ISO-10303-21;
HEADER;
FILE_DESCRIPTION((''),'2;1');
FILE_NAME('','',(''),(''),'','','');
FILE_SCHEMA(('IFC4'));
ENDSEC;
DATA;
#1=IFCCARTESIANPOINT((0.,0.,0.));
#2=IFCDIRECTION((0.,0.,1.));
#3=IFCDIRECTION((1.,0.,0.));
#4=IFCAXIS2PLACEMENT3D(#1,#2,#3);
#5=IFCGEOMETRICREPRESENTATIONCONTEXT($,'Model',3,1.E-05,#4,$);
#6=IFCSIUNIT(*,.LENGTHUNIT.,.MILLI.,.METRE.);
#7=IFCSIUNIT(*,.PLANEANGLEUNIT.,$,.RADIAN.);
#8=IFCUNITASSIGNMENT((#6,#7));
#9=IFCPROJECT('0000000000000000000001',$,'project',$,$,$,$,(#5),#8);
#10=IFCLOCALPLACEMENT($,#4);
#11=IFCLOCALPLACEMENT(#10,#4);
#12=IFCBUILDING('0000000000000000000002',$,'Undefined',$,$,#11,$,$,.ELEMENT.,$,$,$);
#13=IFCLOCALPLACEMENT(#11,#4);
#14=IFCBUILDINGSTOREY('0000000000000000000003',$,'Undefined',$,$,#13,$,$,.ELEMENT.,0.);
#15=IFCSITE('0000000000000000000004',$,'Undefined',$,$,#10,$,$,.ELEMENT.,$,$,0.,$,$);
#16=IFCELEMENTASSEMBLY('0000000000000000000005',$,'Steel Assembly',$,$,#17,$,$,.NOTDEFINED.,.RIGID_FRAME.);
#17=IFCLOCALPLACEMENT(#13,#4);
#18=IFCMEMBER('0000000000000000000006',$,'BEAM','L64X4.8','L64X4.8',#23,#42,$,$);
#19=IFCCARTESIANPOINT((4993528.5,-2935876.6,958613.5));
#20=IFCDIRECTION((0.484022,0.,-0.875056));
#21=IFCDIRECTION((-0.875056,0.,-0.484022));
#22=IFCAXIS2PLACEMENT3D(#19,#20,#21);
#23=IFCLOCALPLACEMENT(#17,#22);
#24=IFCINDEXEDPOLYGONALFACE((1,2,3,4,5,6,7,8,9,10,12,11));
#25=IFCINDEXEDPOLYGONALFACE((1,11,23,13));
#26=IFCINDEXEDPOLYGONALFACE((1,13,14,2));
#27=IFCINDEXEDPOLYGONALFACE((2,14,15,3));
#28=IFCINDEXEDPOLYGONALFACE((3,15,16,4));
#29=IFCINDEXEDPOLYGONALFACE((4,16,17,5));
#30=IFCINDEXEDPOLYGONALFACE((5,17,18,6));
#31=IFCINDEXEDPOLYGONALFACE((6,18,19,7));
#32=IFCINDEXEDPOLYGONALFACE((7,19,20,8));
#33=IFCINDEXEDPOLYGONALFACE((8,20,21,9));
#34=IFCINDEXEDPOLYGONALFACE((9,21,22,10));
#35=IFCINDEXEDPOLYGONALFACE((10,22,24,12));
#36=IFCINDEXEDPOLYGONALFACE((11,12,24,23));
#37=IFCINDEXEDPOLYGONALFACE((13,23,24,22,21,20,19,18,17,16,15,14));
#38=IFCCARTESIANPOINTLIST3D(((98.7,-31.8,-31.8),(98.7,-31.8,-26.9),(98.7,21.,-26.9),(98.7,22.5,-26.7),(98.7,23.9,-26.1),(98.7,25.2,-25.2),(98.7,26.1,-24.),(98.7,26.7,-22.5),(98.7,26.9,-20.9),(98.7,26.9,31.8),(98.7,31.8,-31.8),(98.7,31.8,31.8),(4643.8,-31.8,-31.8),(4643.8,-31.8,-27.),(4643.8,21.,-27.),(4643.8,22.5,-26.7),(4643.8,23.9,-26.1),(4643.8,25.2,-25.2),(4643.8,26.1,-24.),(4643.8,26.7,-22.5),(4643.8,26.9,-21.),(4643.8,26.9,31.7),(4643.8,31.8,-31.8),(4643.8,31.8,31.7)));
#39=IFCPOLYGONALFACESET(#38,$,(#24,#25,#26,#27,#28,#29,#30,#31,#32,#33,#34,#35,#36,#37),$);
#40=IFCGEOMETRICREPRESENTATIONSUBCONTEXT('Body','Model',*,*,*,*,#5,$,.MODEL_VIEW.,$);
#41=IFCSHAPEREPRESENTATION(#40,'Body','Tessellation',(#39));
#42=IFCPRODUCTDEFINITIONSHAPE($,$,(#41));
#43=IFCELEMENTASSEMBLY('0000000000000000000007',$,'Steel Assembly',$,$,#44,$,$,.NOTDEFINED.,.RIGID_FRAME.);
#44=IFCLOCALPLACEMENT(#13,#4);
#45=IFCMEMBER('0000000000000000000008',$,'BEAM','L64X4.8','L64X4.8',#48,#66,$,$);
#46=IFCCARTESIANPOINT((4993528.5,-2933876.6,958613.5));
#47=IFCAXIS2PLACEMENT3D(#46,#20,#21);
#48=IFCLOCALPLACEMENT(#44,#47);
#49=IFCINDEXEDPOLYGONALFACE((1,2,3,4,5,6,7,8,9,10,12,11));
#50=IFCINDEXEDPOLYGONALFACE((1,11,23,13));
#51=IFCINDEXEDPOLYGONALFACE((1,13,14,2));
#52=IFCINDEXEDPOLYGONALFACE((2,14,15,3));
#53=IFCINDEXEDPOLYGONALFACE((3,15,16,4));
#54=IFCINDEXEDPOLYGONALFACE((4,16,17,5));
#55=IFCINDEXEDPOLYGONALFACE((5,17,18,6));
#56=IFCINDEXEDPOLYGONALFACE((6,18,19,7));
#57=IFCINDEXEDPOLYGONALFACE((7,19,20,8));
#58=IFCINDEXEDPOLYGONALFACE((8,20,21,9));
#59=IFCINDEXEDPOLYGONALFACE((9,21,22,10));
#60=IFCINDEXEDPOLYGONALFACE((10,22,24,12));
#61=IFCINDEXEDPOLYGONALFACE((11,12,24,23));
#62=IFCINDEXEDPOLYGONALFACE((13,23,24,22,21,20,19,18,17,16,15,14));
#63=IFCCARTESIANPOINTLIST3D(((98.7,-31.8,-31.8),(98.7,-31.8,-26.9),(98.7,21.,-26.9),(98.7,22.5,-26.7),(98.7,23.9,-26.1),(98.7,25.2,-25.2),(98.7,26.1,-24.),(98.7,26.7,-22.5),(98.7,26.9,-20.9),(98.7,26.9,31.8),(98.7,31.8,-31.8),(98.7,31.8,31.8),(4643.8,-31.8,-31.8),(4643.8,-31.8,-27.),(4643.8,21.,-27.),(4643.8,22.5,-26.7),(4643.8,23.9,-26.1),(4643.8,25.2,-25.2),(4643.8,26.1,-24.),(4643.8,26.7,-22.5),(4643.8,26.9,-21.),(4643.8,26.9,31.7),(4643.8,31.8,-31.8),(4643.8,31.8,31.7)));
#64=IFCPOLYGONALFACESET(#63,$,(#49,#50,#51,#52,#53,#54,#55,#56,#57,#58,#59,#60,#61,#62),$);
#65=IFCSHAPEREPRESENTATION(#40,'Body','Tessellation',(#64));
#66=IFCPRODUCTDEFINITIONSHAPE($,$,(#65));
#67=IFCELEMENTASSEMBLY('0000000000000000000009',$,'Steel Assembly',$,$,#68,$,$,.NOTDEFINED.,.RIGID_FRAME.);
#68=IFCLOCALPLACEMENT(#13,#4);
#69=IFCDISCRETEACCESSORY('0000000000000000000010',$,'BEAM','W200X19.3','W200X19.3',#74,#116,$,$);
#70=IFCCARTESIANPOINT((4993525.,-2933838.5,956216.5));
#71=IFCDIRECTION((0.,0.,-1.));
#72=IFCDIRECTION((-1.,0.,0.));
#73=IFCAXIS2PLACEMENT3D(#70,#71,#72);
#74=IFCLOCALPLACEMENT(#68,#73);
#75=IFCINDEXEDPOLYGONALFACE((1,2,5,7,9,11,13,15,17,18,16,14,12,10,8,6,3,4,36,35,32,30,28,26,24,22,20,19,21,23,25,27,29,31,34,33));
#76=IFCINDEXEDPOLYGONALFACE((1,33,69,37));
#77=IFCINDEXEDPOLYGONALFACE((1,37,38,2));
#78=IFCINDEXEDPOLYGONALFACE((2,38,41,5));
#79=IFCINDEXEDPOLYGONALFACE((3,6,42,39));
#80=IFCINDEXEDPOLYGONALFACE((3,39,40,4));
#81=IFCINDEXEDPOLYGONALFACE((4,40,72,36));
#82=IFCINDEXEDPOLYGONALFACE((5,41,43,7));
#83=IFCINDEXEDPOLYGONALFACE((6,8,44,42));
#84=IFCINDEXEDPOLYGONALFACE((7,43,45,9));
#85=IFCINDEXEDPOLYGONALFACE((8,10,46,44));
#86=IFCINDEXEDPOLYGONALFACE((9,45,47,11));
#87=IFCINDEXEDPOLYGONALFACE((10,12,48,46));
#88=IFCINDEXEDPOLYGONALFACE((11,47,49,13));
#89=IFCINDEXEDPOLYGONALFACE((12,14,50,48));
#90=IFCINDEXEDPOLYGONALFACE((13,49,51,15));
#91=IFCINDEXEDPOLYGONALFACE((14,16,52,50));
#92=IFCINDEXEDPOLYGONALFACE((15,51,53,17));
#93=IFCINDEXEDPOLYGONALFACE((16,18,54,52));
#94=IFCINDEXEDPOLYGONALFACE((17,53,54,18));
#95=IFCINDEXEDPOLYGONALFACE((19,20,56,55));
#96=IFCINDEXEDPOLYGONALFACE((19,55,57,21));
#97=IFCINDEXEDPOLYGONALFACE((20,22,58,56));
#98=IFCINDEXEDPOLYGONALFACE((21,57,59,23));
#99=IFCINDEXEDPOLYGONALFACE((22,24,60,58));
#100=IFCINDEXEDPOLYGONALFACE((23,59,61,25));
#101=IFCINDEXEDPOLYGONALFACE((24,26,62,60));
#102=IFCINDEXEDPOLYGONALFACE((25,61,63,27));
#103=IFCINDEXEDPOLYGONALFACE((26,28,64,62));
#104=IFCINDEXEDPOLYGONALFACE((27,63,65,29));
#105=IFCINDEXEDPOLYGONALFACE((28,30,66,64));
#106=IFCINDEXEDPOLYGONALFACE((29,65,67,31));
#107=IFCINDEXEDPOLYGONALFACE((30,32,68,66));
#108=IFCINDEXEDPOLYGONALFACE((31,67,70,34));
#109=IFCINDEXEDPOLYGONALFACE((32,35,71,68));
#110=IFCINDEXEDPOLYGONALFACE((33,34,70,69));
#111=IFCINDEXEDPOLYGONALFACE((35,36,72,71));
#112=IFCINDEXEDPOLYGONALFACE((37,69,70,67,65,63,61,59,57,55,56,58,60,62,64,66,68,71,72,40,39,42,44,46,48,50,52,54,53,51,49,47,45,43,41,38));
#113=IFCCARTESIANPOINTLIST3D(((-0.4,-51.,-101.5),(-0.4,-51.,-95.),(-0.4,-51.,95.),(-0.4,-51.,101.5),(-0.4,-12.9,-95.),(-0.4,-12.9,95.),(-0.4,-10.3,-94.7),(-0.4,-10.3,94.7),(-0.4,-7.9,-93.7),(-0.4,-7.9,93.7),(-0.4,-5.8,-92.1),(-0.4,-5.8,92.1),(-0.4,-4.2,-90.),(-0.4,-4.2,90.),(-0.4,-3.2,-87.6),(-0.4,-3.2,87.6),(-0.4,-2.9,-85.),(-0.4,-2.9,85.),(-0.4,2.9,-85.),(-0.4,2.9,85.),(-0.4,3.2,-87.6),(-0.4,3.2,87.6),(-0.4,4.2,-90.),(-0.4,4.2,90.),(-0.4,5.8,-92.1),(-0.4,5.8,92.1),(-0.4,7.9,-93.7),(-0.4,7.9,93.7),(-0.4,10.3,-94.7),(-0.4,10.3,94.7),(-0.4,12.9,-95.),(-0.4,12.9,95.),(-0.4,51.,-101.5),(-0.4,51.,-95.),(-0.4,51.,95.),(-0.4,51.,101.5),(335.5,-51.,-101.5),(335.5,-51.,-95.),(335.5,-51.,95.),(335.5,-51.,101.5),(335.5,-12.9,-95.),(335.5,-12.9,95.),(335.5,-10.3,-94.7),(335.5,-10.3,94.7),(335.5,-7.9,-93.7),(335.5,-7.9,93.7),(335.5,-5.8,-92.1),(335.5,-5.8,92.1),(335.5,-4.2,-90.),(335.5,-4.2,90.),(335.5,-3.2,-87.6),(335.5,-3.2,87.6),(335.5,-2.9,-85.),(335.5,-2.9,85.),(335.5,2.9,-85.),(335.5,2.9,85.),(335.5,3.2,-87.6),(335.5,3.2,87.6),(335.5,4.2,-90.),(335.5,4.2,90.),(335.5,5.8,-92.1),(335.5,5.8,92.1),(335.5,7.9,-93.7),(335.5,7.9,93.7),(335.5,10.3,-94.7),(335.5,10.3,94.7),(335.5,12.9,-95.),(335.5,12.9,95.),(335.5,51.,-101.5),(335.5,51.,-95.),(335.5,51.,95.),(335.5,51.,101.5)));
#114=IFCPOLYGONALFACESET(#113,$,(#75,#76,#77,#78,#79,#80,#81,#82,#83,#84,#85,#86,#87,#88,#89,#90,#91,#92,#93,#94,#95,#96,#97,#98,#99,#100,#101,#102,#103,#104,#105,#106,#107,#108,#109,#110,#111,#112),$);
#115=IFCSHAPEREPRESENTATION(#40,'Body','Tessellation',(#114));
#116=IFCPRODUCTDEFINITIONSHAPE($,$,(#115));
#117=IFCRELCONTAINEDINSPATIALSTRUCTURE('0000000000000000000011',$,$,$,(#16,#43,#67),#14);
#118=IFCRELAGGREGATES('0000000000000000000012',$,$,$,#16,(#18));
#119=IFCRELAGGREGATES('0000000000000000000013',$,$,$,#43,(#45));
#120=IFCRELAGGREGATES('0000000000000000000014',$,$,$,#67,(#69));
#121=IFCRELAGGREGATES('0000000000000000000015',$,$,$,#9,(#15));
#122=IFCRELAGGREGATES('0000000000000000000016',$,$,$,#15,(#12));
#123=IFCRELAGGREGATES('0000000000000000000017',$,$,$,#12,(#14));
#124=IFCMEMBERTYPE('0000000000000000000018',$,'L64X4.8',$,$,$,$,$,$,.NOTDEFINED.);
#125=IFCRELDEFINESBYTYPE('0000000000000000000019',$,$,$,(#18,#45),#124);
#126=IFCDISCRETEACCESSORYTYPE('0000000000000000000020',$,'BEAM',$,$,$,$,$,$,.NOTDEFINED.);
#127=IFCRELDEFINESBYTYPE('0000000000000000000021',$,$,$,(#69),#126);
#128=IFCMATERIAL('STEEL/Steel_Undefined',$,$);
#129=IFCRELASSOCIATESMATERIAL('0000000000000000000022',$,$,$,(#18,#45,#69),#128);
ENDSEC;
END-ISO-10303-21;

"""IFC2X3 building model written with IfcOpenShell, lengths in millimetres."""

from ifc_helpers import new_model, si_unit, frame, origin_with_axes, origin_2d_with_axis, place, context, subcontext, project, spatial, i_section, l_section, extrude, clip, halfspace, material, type_object, element, aggregate, save


model = new_model("IFC2X3")

# Units and contexts
model_context = context("Model", 3, precision=1e-05, world=origin_with_axes())
body_context = subcontext(model_context, "Body", "Model", "MODEL_VIEW")
ifc_project = project(units=[si_unit("LENGTHUNIT", "METRE", prefix="MILLI"), si_unit("PLANEANGLEUNIT", "RADIAN")], contexts=[model_context])

# Site, building, storey
site_placement = place(None, origin_with_axes())
site = spatial("IfcSite", under=ifc_project, at=site_placement, Name="Undefined", CompositionType="ELEMENT", RefElevation=0.0)
building_placement = place(site_placement, origin_with_axes())
building = spatial("IfcBuilding", under=site, at=building_placement, Name="Undefined", CompositionType="ELEMENT")
storey_placement = place(building_placement, origin_with_axes())
storey = spatial("IfcBuildingStorey", under=building, at=storey_placement, Name="Undefined", CompositionType="ELEMENT", Elevation=0.0)

# Element assemblies, members
assembly_1_placement = place(storey_placement, origin_with_axes())
assembly_1 = element("IfcElementAssembly", 1, at=assembly_1_placement, inside=storey, Name="Steel Assembly", AssemblyPlace="NOTDEFINED", PredefinedType="RIGID_FRAME")
ifc_material_1 = material(Name="STEEL/Steel_Undefined")
member_type = type_object("IfcMemberType", Name="L64X4.8", PredefinedType="NOTDEFINED")
member_1_placement = place(assembly_1_placement, frame((4993528.5, -2935876.6, 958613.5), z_axis=(0.484022, 0.0, -0.875056), x_axis=(-0.875056, 0.0, -0.484022)))
member_1 = element("IfcMember", 2, at=member_1_placement, type_object=member_type, material=ifc_material_1, Name="BEAM", Description="L64X4.8", ObjectType="L64X4.8", context=body_context, shape_type="Clipping", body=[
    clip(clip(extrude(l_section(Depth=63.5, Width=63.5, Thickness=4.8, FilletRadius=6.0, at=origin_2d_with_axis()), frame((4698.2, 0.0, 0.0), z_axis=(-1.0, 0.0, 0.0), x_axis=(0.0, -1.0, 0.0)), (0.0, 0.0, 1.0), 4653.8), halfspace(frame((4643.8, 31.8, 0.0), z_axis=(-1.0, 0.0, 0.0), x_axis=(0.0, 0.0, -1.0)), True)), halfspace(frame((98.7, 31.8, 0.0), z_axis=(1.0, 0.0, 0.0), x_axis=(0.0, 0.0, 1.0)), True)),
])
aggregate(assembly_1, [member_1])
assembly_2_placement = place(storey_placement, origin_with_axes())
assembly_2 = element("IfcElementAssembly", 3, at=assembly_2_placement, inside=storey, Name="Steel Assembly", AssemblyPlace="NOTDEFINED", PredefinedType="RIGID_FRAME")
member_2_placement = place(assembly_2_placement, frame((4993528.5, -2933876.6, 958613.5), z_axis=(0.484022, 0.0, -0.875056), x_axis=(-0.875056, 0.0, -0.484022)))
member_2 = element("IfcMember", 4, at=member_2_placement, type_object=member_type, material=ifc_material_1, Name="BEAM", Description="L64X4.8", ObjectType="L64X4.8", context=body_context, shape_type="Clipping", body=[
    clip(clip(extrude(l_section(Depth=63.5, Width=63.5, Thickness=4.8, FilletRadius=6.0, at=origin_2d_with_axis()), frame((4698.2, 0.0, 0.0), z_axis=(-1.0, 0.0, 0.0), x_axis=(0.0, -1.0, 0.0)), (0.0, 0.0, 1.0), 4653.8), halfspace(frame((4643.8, 31.8, 0.0), z_axis=(-1.0, 0.0, 0.0), x_axis=(0.0, 0.0, -1.0)), True)), halfspace(frame((98.7, 31.8, 0.0), z_axis=(1.0, 0.0, 0.0), x_axis=(0.0, 0.0, 1.0)), True)),
])
aggregate(assembly_2, [member_2])

# Element assembly
assembly_3_placement = place(storey_placement, origin_with_axes())
assembly_3 = element("IfcElementAssembly", 5, at=assembly_3_placement, inside=storey, Name="Steel Assembly", AssemblyPlace="NOTDEFINED", PredefinedType="RIGID_FRAME")

# Discrete accessory
discrete_accessory_type_1 = type_object("IfcDiscreteAccessoryType", Name="BEAM")
discrete_accessory_1_placement = place(assembly_3_placement, frame((4993525.0, -2933838.5, 956216.5), z_axis=(0.0, 0.0, -1.0), x_axis=(-1.0, 0.0, 0.0)))
discrete_accessory_1 = element("IfcDiscreteAccessory", 6, at=discrete_accessory_1_placement, type_object=discrete_accessory_type_1, material=ifc_material_1, Name="BEAM", Description="W200X19.3", ObjectType="W200X19.3", context=body_context, shape_type="Clipping", body=[
    clip(clip(extrude(i_section(OverallWidth=102.0, OverallDepth=203.0, WebThickness=5.8, FlangeThickness=6.5, FilletRadius=10.0, at=origin_2d_with_axis()), frame((335.5, 0.0, 0.0), z_axis=(-1.0, 0.0, 0.0), x_axis=(0.0, -1.0, 0.0)), (0.0, 0.0, 1.0), 335.9), halfspace(frame((335.5, 0.0, -1000.0), z_axis=(-1.0, 0.0, 0.0), x_axis=(0.0, 1.0, 0.0)), True)), halfspace(frame((-0.4, 0.0, -1101.5), z_axis=(-1.0, 0.0, 0.0), x_axis=(0.0, 1.0, 0.0)), False)),
])
aggregate(assembly_3, [discrete_accessory_1])

save(model, "model.ifc")
